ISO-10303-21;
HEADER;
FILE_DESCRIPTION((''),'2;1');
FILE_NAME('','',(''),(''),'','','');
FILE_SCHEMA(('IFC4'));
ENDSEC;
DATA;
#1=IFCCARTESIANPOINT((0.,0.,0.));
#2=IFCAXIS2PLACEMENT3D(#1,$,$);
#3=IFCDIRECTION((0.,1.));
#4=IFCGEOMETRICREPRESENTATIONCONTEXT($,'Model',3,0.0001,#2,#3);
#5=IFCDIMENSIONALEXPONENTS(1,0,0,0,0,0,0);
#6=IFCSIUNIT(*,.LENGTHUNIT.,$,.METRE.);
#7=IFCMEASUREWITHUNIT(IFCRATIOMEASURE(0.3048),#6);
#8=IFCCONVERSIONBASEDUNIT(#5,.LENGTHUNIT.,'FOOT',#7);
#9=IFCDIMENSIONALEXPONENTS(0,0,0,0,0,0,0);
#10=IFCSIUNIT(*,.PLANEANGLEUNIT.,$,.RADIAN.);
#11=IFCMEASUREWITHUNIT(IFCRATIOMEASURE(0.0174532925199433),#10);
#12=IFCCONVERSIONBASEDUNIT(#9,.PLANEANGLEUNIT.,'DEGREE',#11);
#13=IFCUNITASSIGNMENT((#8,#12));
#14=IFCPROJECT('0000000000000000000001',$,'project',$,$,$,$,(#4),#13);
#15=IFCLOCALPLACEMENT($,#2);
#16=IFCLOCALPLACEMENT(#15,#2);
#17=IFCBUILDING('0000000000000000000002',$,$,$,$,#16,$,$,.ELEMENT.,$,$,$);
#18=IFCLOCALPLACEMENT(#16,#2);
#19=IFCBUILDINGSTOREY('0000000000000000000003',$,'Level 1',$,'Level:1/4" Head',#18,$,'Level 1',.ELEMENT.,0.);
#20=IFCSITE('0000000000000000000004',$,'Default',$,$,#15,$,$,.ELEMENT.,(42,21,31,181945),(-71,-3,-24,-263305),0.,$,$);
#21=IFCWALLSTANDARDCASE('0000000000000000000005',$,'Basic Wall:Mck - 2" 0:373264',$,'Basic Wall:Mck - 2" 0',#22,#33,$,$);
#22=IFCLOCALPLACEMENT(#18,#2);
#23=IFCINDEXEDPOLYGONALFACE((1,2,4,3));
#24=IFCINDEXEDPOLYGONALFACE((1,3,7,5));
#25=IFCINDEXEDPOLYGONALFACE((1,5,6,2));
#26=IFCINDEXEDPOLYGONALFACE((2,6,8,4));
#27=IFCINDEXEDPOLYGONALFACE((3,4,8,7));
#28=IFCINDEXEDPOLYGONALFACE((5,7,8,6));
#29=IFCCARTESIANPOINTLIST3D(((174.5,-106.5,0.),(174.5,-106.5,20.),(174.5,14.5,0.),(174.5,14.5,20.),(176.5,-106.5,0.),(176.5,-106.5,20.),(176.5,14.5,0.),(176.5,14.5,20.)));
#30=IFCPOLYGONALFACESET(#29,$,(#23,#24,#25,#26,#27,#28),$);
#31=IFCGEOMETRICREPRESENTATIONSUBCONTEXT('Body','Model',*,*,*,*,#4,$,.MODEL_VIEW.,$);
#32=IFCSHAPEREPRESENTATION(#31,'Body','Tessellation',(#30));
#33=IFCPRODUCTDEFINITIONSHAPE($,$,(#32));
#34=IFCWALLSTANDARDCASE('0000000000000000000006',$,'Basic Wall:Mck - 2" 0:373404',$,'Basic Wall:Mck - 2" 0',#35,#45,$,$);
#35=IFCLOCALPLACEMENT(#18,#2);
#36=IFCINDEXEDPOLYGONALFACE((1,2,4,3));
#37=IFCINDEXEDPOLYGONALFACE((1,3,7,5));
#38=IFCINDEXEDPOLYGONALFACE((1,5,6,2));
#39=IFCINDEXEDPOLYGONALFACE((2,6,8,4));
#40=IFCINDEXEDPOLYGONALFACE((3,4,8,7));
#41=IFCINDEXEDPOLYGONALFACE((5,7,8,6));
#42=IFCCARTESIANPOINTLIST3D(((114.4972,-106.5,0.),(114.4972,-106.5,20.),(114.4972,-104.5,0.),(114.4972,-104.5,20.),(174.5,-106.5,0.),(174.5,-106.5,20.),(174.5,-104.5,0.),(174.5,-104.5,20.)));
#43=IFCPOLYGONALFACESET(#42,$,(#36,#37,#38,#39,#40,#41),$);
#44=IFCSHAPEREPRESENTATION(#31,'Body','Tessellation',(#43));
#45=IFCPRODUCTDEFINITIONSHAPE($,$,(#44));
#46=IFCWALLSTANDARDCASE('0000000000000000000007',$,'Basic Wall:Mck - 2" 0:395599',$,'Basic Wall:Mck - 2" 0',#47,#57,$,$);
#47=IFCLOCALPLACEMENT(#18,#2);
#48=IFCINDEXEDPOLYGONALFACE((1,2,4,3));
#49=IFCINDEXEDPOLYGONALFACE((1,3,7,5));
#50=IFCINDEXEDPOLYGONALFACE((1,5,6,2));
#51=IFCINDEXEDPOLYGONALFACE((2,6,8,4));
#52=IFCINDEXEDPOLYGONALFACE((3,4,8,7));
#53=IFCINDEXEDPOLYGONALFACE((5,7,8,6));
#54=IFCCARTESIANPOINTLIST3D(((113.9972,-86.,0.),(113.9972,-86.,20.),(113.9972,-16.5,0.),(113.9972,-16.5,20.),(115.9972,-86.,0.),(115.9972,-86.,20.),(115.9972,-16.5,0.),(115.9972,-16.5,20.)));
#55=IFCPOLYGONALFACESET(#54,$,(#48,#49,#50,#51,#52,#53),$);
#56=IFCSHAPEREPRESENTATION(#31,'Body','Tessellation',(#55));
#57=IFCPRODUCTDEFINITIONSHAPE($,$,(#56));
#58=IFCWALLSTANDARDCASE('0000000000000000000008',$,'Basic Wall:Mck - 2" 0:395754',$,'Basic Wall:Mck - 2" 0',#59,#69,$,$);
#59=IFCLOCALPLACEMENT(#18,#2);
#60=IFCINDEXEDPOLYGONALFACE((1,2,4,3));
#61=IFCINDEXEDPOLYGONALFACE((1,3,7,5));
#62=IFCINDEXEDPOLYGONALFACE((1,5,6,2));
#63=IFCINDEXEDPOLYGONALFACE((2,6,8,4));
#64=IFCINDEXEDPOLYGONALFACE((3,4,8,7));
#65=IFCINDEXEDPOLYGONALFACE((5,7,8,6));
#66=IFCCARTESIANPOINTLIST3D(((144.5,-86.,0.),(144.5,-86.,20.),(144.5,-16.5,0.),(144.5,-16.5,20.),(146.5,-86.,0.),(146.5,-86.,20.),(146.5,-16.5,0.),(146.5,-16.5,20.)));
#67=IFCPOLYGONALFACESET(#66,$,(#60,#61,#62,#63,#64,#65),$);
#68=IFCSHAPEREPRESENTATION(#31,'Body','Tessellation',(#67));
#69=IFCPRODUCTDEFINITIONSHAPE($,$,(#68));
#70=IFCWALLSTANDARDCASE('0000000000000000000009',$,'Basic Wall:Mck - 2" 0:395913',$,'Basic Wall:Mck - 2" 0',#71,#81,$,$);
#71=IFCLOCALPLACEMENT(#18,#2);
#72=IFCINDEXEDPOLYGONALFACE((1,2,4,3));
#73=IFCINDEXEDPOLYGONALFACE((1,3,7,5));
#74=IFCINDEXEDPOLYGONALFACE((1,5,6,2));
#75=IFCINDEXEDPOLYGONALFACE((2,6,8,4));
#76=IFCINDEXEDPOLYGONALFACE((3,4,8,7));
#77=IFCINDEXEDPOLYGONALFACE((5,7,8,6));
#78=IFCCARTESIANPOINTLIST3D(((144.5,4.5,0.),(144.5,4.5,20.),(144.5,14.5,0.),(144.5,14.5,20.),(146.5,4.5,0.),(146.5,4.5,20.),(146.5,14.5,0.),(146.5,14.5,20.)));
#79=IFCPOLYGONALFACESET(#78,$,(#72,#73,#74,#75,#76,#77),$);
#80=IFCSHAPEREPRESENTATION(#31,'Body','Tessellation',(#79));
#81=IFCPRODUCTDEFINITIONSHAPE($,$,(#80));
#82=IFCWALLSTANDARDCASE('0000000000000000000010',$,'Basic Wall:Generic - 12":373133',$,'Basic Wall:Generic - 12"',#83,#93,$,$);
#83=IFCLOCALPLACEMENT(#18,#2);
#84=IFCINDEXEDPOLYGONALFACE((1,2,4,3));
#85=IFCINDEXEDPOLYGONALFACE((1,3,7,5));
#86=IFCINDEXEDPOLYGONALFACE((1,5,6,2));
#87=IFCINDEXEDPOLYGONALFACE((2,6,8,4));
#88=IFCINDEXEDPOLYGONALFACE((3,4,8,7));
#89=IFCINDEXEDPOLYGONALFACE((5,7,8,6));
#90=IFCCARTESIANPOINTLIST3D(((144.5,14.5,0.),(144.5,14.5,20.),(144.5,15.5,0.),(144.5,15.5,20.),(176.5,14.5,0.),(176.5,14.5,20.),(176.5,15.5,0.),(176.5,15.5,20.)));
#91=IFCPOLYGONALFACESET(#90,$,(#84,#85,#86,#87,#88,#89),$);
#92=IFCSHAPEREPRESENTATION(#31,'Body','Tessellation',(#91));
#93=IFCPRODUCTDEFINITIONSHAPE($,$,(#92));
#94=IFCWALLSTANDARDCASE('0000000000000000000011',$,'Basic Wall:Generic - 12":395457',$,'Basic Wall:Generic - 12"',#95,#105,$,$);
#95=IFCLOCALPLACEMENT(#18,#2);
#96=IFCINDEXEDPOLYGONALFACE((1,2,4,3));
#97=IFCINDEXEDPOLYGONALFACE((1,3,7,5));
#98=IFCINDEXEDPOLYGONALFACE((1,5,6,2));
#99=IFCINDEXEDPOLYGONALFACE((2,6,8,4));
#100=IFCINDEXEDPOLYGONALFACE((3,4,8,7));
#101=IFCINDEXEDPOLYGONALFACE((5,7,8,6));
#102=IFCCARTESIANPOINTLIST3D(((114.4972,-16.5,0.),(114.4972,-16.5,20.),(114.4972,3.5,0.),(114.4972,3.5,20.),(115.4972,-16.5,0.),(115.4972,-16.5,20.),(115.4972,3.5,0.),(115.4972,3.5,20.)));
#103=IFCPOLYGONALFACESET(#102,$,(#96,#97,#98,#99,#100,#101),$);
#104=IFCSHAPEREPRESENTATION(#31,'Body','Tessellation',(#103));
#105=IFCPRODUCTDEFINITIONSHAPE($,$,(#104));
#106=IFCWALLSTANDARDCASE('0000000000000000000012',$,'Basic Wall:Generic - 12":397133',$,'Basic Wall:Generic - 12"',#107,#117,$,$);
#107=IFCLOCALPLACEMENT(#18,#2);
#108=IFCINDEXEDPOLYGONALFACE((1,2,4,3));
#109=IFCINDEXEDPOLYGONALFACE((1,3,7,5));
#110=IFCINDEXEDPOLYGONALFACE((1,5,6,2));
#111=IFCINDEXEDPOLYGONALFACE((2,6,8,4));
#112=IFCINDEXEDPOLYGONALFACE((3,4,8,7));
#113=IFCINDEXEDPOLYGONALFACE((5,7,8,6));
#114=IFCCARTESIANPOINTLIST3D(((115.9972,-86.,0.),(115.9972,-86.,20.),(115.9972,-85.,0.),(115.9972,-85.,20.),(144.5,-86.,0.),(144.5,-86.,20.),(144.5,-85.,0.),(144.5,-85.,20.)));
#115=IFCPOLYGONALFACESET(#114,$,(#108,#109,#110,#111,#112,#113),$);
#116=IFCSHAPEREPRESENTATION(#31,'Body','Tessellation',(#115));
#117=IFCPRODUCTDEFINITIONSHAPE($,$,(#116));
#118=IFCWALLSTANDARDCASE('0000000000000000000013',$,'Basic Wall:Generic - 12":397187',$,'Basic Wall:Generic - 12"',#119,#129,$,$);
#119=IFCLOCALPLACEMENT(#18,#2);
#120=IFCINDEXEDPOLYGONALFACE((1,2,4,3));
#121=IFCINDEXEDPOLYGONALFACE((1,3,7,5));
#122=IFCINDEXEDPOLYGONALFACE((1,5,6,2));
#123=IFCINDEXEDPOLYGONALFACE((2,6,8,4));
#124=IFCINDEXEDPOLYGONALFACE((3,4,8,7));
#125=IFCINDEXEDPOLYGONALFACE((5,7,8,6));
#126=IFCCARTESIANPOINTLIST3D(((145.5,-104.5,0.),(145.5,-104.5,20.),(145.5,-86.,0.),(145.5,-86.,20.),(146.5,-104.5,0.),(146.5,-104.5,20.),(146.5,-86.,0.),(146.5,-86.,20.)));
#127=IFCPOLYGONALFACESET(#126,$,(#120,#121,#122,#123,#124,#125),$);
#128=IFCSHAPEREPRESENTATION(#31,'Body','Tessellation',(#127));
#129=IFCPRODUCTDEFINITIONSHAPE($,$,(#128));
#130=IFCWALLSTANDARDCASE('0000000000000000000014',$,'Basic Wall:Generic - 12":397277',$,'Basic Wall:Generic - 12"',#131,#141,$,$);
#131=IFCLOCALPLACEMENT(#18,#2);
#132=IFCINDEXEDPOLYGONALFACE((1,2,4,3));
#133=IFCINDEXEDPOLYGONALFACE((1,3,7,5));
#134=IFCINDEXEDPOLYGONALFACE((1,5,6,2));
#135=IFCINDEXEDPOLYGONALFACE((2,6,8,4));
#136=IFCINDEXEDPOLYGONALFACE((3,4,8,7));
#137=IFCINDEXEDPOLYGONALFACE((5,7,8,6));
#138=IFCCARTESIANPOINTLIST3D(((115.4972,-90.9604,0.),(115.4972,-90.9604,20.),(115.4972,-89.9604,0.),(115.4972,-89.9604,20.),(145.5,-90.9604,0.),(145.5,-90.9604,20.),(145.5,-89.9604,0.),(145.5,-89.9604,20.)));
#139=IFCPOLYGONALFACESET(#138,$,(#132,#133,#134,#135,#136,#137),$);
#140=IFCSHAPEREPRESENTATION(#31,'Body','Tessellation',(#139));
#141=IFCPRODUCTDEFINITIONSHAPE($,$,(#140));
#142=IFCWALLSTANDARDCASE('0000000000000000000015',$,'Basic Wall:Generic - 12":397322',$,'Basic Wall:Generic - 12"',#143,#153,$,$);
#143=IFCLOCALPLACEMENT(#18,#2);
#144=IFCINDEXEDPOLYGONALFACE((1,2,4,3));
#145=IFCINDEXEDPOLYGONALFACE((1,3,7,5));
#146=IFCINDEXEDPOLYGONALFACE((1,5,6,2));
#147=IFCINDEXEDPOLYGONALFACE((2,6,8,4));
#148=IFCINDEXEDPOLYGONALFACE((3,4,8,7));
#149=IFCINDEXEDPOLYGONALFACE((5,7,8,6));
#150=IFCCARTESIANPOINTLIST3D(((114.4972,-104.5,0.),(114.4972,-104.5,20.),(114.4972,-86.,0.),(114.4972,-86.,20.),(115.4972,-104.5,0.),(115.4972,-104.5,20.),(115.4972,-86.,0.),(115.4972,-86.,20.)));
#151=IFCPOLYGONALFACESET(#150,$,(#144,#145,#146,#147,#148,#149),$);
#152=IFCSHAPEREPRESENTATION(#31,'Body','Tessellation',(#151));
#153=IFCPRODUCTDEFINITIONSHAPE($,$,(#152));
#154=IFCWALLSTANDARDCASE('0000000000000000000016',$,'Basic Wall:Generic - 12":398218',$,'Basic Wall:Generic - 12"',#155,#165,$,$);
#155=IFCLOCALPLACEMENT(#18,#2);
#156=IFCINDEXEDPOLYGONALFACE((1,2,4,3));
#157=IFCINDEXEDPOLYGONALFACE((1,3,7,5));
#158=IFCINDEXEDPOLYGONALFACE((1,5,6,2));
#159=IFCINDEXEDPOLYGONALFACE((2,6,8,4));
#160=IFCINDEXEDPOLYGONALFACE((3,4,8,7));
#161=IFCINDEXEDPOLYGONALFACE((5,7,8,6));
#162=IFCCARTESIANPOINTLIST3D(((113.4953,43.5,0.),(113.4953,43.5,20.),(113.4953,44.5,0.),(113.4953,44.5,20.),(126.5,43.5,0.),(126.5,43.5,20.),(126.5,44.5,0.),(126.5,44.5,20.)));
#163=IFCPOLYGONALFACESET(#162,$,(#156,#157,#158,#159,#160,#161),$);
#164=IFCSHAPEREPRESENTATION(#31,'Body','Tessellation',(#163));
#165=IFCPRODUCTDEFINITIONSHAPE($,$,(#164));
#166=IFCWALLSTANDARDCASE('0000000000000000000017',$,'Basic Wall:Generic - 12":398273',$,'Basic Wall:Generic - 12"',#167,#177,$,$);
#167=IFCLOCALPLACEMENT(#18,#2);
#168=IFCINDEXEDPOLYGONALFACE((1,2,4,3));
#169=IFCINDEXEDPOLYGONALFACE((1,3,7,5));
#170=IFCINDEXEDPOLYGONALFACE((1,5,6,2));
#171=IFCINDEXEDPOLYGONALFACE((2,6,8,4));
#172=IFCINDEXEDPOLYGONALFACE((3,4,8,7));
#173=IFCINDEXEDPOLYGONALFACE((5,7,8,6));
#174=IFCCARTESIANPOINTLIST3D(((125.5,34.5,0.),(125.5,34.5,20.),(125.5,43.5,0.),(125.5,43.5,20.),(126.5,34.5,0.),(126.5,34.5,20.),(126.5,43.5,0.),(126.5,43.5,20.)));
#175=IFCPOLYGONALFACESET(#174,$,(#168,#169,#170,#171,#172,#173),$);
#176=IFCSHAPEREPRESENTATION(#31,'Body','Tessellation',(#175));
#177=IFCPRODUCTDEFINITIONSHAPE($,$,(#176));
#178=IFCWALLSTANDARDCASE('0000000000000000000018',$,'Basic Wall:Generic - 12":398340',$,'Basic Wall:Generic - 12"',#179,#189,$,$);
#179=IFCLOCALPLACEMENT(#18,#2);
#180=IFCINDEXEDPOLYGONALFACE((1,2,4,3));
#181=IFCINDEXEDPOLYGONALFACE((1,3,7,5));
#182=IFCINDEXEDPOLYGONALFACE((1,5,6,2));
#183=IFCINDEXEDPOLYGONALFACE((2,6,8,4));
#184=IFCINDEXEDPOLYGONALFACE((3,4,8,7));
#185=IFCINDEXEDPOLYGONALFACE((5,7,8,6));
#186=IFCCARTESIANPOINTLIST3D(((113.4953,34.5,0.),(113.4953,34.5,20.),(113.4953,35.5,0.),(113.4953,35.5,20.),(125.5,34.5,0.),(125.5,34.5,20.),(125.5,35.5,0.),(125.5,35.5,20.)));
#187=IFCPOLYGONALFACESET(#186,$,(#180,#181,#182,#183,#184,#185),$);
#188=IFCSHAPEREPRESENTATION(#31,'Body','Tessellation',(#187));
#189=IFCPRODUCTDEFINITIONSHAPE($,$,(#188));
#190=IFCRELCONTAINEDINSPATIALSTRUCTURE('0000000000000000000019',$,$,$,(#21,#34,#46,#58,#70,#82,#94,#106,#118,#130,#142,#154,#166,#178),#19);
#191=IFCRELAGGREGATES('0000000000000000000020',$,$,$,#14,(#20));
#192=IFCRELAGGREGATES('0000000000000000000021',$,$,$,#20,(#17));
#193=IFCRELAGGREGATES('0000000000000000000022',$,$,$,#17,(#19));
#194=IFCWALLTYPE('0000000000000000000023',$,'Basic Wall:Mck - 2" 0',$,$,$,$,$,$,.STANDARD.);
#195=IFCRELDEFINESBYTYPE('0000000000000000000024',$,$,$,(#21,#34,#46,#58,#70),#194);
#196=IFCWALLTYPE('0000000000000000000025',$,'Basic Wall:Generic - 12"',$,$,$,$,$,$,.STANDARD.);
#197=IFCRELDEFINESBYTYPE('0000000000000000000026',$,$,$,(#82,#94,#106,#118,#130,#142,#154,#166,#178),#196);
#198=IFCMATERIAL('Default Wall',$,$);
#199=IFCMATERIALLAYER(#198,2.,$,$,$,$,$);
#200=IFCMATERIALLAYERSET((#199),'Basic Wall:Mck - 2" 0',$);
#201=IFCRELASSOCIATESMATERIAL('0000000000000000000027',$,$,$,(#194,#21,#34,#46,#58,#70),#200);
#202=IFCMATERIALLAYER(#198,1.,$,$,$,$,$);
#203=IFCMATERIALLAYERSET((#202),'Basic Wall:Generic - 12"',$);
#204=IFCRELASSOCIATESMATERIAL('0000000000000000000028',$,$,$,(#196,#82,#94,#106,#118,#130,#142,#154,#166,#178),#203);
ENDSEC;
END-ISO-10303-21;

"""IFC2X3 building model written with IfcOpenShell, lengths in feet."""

from ifc_helpers import new_model, entity, si_unit, converted_unit, direction, frame, frame_2d, origin, place, context, subcontext, project, spatial, rectangle, extrude, material, layer, layer_set, layer_usage, type_object, element, save


model = new_model("IFC2X3")

# Units and contexts
model_context = context("Model", 3, precision=0.0001, world=origin(), true_north=direction((0.0, 1.0)))
body_context = subcontext(model_context, "Body", "Model", "MODEL_VIEW")
ifc_project = project(units=[converted_unit("LENGTHUNIT", "FOOT", entity("IfcRatioMeasure", 0.3048), si_unit("LENGTHUNIT", "METRE"), dimensions=[1, 0, 0, 0, 0, 0, 0]), converted_unit("PLANEANGLEUNIT", "DEGREE", entity("IfcRatioMeasure", 0.0174532925199433), si_unit("PLANEANGLEUNIT", "RADIAN"), dimensions=[0, 0, 0, 0, 0, 0, 0])], contexts=[model_context])

# Site, building, storey
site_placement = place(None, origin())
site = spatial("IfcSite", under=ifc_project, at=site_placement, Name="Default", CompositionType="ELEMENT", RefLatitude=(42, 21, 31, 181945), RefLongitude=(-71, -3, -24, -263305), RefElevation=0.0)
building_placement = place(site_placement, origin())
building = spatial("IfcBuilding", under=site, at=building_placement, CompositionType="ELEMENT")
storey_placement = place(building_placement, origin())
storey = spatial("IfcBuildingStorey", under=building, at=storey_placement, Name="Level 1", ObjectType="Level:1/4\" Head", LongName="Level 1", CompositionType="ELEMENT", Elevation=0.0)

# Walls
ifc_material = material(Name="Default Wall")
ifc_layer_1 = layer(ifc_material, 2.0)
ifc_layer_set_1 = layer_set([ifc_layer_1], Name="Basic Wall:Mck - 2\" 0")
ifc_layer_usage_1 = layer_usage(ifc_layer_set_1, "AXIS2", "NEGATIVE", 1.0)
wall_type_1 = type_object("IfcWallType", Name="Basic Wall:Mck - 2\" 0", PredefinedType="STANDARD", material=ifc_layer_set_1)
wall_1_placement = place(storey_placement, frame((175.5, 14.5, 0.0), z_axis=(0.0, 0.0, 1.0), x_axis=(0.0, -1.0, 0.0)))
element("IfcWallStandardCase", 1, at=wall_1_placement, inside=storey, type_object=wall_type_1, material=ifc_layer_usage_1, Name="Basic Wall:Mck - 2\" 0:373264", ObjectType="Basic Wall:Mck - 2\" 0", context=body_context, shape_type="SweptSolid", body=[
    extrude(rectangle(XDim=121.0, YDim=2.0, at=frame_2d((60.5, 0.0), x_axis=(-1.0, 0.0))), origin(), (0.0, 0.0, 1.0), 20.0),
])
ifc_layer_usage_2 = layer_usage(ifc_layer_set_1, "AXIS2", "NEGATIVE", 1.0)
wall_2_placement = place(storey_placement, frame((174.5, -105.5, 0.0), z_axis=(0.0, 0.0, 1.0), x_axis=(-1.0, 0.0, 0.0)))
element("IfcWallStandardCase", 2, at=wall_2_placement, inside=storey, type_object=wall_type_1, material=ifc_layer_usage_2, Name="Basic Wall:Mck - 2\" 0:373404", ObjectType="Basic Wall:Mck - 2\" 0", context=body_context, shape_type="SweptSolid", body=[
    extrude(rectangle(XDim=60.0028, YDim=2.0, at=frame_2d((30.0014, 0.0), x_axis=(-1.0, 0.0))), origin(), (0.0, 0.0, 1.0), 20.0),
])
ifc_layer_usage_3 = layer_usage(ifc_layer_set_1, "AXIS2", "NEGATIVE", 1.0)
wall_3_placement = place(storey_placement, frame((114.9972, -16.5, 0.0), z_axis=(0.0, 0.0, 1.0), x_axis=(0.0, -1.0, 0.0)))
element("IfcWallStandardCase", 3, at=wall_3_placement, inside=storey, type_object=wall_type_1, material=ifc_layer_usage_3, Name="Basic Wall:Mck - 2\" 0:395599", ObjectType="Basic Wall:Mck - 2\" 0", context=body_context, shape_type="SweptSolid", body=[
    extrude(rectangle(XDim=69.5, YDim=2.0, at=frame_2d((34.75, 0.0), x_axis=(-1.0, 0.0))), origin(), (0.0, 0.0, 1.0), 20.0),
])
ifc_layer_usage_4 = layer_usage(ifc_layer_set_1, "AXIS2", "NEGATIVE", 1.0)
wall_4_placement = place(storey_placement, frame((145.5, -16.5, 0.0), z_axis=(0.0, 0.0, 1.0), x_axis=(0.0, -1.0, 0.0)))
element("IfcWallStandardCase", 4, at=wall_4_placement, inside=storey, type_object=wall_type_1, material=ifc_layer_usage_4, Name="Basic Wall:Mck - 2\" 0:395754", ObjectType="Basic Wall:Mck - 2\" 0", context=body_context, shape_type="SweptSolid", body=[
    extrude(rectangle(XDim=69.5, YDim=2.0, at=frame_2d((34.75, 0.0), x_axis=(-1.0, 0.0))), origin(), (0.0, 0.0, 1.0), 20.0),
])
ifc_layer_usage_5 = layer_usage(ifc_layer_set_1, "AXIS2", "NEGATIVE", 1.0)
wall_5_placement = place(storey_placement, frame((145.5, 14.5, 0.0), z_axis=(0.0, 0.0, 1.0), x_axis=(0.0, -1.0, 0.0)))
element("IfcWallStandardCase", 5, at=wall_5_placement, inside=storey, type_object=wall_type_1, material=ifc_layer_usage_5, Name="Basic Wall:Mck - 2\" 0:395913", ObjectType="Basic Wall:Mck - 2\" 0", context=body_context, shape_type="SweptSolid", body=[
    extrude(rectangle(XDim=10.0, YDim=2.0, at=frame_2d((5.0, 0.0), x_axis=(-1.0, 0.0))), origin(), (0.0, 0.0, 1.0), 20.0),
])
ifc_layer_2 = layer(ifc_material, 1.0)
ifc_layer_set_2 = layer_set([ifc_layer_2], Name="Basic Wall:Generic - 12\"")
ifc_layer_usage_6 = layer_usage(ifc_layer_set_2, "AXIS2", "NEGATIVE", 0.5)
wall_type_2 = type_object("IfcWallType", Name="Basic Wall:Generic - 12\"", PredefinedType="STANDARD", material=ifc_layer_set_2)
wall_6_placement = place(storey_placement, frame((176.5, 15.0, 0.0), z_axis=(0.0, 0.0, 1.0), x_axis=(-1.0, 0.0, 0.0)))
element("IfcWallStandardCase", 6, at=wall_6_placement, inside=storey, type_object=wall_type_2, material=ifc_layer_usage_6, Name="Basic Wall:Generic - 12\":373133", ObjectType="Basic Wall:Generic - 12\"", context=body_context, shape_type="SweptSolid", body=[
    extrude(rectangle(XDim=32.0, YDim=1.0, at=frame_2d((16.0, 0.0), x_axis=(-1.0, 0.0))), origin(), (0.0, 0.0, 1.0), 20.0),
])
ifc_layer_usage_7 = layer_usage(ifc_layer_set_2, "AXIS2", "NEGATIVE", 0.5)
wall_7_placement = place(storey_placement, frame((114.9972, 3.5, 0.0), z_axis=(0.0, 0.0, 1.0), x_axis=(0.0, -1.0, 0.0)))
element("IfcWallStandardCase", 7, at=wall_7_placement, inside=storey, type_object=wall_type_2, material=ifc_layer_usage_7, Name="Basic Wall:Generic - 12\":395457", ObjectType="Basic Wall:Generic - 12\"", context=body_context, shape_type="SweptSolid", body=[
    extrude(rectangle(XDim=20.0, YDim=1.0, at=frame_2d((10.0, 0.0), x_axis=(-1.0, 0.0))), origin(), (0.0, 0.0, 1.0), 20.0),
])
ifc_layer_usage_8 = layer_usage(ifc_layer_set_2, "AXIS2", "NEGATIVE", 0.5)
wall_8_placement = place(storey_placement, frame((115.9972, -85.5, 0.0)))
element("IfcWallStandardCase", 8, at=wall_8_placement, inside=storey, type_object=wall_type_2, material=ifc_layer_usage_8, Name="Basic Wall:Generic - 12\":397133", ObjectType="Basic Wall:Generic - 12\"", context=body_context, shape_type="SweptSolid", body=[
    extrude(rectangle(XDim=28.5028, YDim=1.0, at=frame_2d((14.2514, 0.0), x_axis=(-1.0, 0.0))), origin(), (0.0, 0.0, 1.0), 20.0),
])
ifc_layer_usage_9 = layer_usage(ifc_layer_set_2, "AXIS2", "NEGATIVE", 0.5)
wall_9_placement = place(storey_placement, frame((146.0, -104.5, 0.0), z_axis=(0.0, 0.0, 1.0), x_axis=(0.0, 1.0, 0.0)))
element("IfcWallStandardCase", 9, at=wall_9_placement, inside=storey, type_object=wall_type_2, material=ifc_layer_usage_9, Name="Basic Wall:Generic - 12\":397187", ObjectType="Basic Wall:Generic - 12\"", context=body_context, shape_type="SweptSolid", body=[
    extrude(rectangle(XDim=18.5, YDim=1.0, at=frame_2d((9.25, 0.0), x_axis=(-1.0, 0.0))), origin(), (0.0, 0.0, 1.0), 20.0),
])
ifc_layer_usage_10 = layer_usage(ifc_layer_set_2, "AXIS2", "NEGATIVE", 0.5)
wall_10_placement = place(storey_placement, frame((145.5, -90.4604, 0.0), z_axis=(0.0, 0.0, 1.0), x_axis=(-1.0, 0.0, 0.0)))
element("IfcWallStandardCase", 10, at=wall_10_placement, inside=storey, type_object=wall_type_2, material=ifc_layer_usage_10, Name="Basic Wall:Generic - 12\":397277", ObjectType="Basic Wall:Generic - 12\"", context=body_context, shape_type="SweptSolid", body=[
    extrude(rectangle(XDim=30.0028, YDim=1.0, at=frame_2d((15.0014, 0.0), x_axis=(-1.0, 0.0))), origin(), (0.0, 0.0, 1.0), 20.0),
])
ifc_layer_usage_11 = layer_usage(ifc_layer_set_2, "AXIS2", "NEGATIVE", 0.5)
wall_11_placement = place(storey_placement, frame((114.9972, -104.5, 0.0), z_axis=(0.0, 0.0, 1.0), x_axis=(0.0, 1.0, 0.0)))
element("IfcWallStandardCase", 11, at=wall_11_placement, inside=storey, type_object=wall_type_2, material=ifc_layer_usage_11, Name="Basic Wall:Generic - 12\":397322", ObjectType="Basic Wall:Generic - 12\"", context=body_context, shape_type="SweptSolid", body=[
    extrude(rectangle(XDim=18.5, YDim=1.0, at=frame_2d((9.25, 0.0), x_axis=(-1.0, 0.0))), origin(), (0.0, 0.0, 1.0), 20.0),
])
ifc_layer_usage_12 = layer_usage(ifc_layer_set_2, "AXIS2", "NEGATIVE", 0.5)
wall_12_placement = place(storey_placement, frame((113.4953, 44.0, 0.0)))
element("IfcWallStandardCase", 12, at=wall_12_placement, inside=storey, type_object=wall_type_2, material=ifc_layer_usage_12, Name="Basic Wall:Generic - 12\":398218", ObjectType="Basic Wall:Generic - 12\"", context=body_context, shape_type="SweptSolid", body=[
    extrude(rectangle(XDim=13.0047, YDim=1.0, at=frame_2d((6.5023, 0.0), x_axis=(-1.0, 0.0))), origin(), (0.0, 0.0, 1.0), 20.0),
])
ifc_layer_usage_13 = layer_usage(ifc_layer_set_2, "AXIS2", "NEGATIVE", 0.5)
wall_13_placement = place(storey_placement, frame((126.0, 43.5, 0.0), z_axis=(0.0, 0.0, 1.0), x_axis=(0.0, -1.0, 0.0)))
element("IfcWallStandardCase", 13, at=wall_13_placement, inside=storey, type_object=wall_type_2, material=ifc_layer_usage_13, Name="Basic Wall:Generic - 12\":398273", ObjectType="Basic Wall:Generic - 12\"", context=body_context, shape_type="SweptSolid", body=[
    extrude(rectangle(XDim=9.0, YDim=1.0, at=frame_2d((4.5, 0.0), x_axis=(-1.0, 0.0))), origin(), (0.0, 0.0, 1.0), 20.0),
])
ifc_layer_usage_14 = layer_usage(ifc_layer_set_2, "AXIS2", "NEGATIVE", 0.5)
wall_14_placement = place(storey_placement, frame((125.5, 35.0, 0.0), z_axis=(0.0, 0.0, 1.0), x_axis=(-1.0, 0.0, 0.0)))
element("IfcWallStandardCase", 14, at=wall_14_placement, inside=storey, type_object=wall_type_2, material=ifc_layer_usage_14, Name="Basic Wall:Generic - 12\":398340", ObjectType="Basic Wall:Generic - 12\"", context=body_context, shape_type="SweptSolid", body=[
    extrude(rectangle(XDim=12.0047, YDim=1.0, at=frame_2d((6.0023, 0.0), x_axis=(-1.0, 0.0))), origin(), (0.0, 0.0, 1.0), 20.0),
])

save(model, "model.ifc")
